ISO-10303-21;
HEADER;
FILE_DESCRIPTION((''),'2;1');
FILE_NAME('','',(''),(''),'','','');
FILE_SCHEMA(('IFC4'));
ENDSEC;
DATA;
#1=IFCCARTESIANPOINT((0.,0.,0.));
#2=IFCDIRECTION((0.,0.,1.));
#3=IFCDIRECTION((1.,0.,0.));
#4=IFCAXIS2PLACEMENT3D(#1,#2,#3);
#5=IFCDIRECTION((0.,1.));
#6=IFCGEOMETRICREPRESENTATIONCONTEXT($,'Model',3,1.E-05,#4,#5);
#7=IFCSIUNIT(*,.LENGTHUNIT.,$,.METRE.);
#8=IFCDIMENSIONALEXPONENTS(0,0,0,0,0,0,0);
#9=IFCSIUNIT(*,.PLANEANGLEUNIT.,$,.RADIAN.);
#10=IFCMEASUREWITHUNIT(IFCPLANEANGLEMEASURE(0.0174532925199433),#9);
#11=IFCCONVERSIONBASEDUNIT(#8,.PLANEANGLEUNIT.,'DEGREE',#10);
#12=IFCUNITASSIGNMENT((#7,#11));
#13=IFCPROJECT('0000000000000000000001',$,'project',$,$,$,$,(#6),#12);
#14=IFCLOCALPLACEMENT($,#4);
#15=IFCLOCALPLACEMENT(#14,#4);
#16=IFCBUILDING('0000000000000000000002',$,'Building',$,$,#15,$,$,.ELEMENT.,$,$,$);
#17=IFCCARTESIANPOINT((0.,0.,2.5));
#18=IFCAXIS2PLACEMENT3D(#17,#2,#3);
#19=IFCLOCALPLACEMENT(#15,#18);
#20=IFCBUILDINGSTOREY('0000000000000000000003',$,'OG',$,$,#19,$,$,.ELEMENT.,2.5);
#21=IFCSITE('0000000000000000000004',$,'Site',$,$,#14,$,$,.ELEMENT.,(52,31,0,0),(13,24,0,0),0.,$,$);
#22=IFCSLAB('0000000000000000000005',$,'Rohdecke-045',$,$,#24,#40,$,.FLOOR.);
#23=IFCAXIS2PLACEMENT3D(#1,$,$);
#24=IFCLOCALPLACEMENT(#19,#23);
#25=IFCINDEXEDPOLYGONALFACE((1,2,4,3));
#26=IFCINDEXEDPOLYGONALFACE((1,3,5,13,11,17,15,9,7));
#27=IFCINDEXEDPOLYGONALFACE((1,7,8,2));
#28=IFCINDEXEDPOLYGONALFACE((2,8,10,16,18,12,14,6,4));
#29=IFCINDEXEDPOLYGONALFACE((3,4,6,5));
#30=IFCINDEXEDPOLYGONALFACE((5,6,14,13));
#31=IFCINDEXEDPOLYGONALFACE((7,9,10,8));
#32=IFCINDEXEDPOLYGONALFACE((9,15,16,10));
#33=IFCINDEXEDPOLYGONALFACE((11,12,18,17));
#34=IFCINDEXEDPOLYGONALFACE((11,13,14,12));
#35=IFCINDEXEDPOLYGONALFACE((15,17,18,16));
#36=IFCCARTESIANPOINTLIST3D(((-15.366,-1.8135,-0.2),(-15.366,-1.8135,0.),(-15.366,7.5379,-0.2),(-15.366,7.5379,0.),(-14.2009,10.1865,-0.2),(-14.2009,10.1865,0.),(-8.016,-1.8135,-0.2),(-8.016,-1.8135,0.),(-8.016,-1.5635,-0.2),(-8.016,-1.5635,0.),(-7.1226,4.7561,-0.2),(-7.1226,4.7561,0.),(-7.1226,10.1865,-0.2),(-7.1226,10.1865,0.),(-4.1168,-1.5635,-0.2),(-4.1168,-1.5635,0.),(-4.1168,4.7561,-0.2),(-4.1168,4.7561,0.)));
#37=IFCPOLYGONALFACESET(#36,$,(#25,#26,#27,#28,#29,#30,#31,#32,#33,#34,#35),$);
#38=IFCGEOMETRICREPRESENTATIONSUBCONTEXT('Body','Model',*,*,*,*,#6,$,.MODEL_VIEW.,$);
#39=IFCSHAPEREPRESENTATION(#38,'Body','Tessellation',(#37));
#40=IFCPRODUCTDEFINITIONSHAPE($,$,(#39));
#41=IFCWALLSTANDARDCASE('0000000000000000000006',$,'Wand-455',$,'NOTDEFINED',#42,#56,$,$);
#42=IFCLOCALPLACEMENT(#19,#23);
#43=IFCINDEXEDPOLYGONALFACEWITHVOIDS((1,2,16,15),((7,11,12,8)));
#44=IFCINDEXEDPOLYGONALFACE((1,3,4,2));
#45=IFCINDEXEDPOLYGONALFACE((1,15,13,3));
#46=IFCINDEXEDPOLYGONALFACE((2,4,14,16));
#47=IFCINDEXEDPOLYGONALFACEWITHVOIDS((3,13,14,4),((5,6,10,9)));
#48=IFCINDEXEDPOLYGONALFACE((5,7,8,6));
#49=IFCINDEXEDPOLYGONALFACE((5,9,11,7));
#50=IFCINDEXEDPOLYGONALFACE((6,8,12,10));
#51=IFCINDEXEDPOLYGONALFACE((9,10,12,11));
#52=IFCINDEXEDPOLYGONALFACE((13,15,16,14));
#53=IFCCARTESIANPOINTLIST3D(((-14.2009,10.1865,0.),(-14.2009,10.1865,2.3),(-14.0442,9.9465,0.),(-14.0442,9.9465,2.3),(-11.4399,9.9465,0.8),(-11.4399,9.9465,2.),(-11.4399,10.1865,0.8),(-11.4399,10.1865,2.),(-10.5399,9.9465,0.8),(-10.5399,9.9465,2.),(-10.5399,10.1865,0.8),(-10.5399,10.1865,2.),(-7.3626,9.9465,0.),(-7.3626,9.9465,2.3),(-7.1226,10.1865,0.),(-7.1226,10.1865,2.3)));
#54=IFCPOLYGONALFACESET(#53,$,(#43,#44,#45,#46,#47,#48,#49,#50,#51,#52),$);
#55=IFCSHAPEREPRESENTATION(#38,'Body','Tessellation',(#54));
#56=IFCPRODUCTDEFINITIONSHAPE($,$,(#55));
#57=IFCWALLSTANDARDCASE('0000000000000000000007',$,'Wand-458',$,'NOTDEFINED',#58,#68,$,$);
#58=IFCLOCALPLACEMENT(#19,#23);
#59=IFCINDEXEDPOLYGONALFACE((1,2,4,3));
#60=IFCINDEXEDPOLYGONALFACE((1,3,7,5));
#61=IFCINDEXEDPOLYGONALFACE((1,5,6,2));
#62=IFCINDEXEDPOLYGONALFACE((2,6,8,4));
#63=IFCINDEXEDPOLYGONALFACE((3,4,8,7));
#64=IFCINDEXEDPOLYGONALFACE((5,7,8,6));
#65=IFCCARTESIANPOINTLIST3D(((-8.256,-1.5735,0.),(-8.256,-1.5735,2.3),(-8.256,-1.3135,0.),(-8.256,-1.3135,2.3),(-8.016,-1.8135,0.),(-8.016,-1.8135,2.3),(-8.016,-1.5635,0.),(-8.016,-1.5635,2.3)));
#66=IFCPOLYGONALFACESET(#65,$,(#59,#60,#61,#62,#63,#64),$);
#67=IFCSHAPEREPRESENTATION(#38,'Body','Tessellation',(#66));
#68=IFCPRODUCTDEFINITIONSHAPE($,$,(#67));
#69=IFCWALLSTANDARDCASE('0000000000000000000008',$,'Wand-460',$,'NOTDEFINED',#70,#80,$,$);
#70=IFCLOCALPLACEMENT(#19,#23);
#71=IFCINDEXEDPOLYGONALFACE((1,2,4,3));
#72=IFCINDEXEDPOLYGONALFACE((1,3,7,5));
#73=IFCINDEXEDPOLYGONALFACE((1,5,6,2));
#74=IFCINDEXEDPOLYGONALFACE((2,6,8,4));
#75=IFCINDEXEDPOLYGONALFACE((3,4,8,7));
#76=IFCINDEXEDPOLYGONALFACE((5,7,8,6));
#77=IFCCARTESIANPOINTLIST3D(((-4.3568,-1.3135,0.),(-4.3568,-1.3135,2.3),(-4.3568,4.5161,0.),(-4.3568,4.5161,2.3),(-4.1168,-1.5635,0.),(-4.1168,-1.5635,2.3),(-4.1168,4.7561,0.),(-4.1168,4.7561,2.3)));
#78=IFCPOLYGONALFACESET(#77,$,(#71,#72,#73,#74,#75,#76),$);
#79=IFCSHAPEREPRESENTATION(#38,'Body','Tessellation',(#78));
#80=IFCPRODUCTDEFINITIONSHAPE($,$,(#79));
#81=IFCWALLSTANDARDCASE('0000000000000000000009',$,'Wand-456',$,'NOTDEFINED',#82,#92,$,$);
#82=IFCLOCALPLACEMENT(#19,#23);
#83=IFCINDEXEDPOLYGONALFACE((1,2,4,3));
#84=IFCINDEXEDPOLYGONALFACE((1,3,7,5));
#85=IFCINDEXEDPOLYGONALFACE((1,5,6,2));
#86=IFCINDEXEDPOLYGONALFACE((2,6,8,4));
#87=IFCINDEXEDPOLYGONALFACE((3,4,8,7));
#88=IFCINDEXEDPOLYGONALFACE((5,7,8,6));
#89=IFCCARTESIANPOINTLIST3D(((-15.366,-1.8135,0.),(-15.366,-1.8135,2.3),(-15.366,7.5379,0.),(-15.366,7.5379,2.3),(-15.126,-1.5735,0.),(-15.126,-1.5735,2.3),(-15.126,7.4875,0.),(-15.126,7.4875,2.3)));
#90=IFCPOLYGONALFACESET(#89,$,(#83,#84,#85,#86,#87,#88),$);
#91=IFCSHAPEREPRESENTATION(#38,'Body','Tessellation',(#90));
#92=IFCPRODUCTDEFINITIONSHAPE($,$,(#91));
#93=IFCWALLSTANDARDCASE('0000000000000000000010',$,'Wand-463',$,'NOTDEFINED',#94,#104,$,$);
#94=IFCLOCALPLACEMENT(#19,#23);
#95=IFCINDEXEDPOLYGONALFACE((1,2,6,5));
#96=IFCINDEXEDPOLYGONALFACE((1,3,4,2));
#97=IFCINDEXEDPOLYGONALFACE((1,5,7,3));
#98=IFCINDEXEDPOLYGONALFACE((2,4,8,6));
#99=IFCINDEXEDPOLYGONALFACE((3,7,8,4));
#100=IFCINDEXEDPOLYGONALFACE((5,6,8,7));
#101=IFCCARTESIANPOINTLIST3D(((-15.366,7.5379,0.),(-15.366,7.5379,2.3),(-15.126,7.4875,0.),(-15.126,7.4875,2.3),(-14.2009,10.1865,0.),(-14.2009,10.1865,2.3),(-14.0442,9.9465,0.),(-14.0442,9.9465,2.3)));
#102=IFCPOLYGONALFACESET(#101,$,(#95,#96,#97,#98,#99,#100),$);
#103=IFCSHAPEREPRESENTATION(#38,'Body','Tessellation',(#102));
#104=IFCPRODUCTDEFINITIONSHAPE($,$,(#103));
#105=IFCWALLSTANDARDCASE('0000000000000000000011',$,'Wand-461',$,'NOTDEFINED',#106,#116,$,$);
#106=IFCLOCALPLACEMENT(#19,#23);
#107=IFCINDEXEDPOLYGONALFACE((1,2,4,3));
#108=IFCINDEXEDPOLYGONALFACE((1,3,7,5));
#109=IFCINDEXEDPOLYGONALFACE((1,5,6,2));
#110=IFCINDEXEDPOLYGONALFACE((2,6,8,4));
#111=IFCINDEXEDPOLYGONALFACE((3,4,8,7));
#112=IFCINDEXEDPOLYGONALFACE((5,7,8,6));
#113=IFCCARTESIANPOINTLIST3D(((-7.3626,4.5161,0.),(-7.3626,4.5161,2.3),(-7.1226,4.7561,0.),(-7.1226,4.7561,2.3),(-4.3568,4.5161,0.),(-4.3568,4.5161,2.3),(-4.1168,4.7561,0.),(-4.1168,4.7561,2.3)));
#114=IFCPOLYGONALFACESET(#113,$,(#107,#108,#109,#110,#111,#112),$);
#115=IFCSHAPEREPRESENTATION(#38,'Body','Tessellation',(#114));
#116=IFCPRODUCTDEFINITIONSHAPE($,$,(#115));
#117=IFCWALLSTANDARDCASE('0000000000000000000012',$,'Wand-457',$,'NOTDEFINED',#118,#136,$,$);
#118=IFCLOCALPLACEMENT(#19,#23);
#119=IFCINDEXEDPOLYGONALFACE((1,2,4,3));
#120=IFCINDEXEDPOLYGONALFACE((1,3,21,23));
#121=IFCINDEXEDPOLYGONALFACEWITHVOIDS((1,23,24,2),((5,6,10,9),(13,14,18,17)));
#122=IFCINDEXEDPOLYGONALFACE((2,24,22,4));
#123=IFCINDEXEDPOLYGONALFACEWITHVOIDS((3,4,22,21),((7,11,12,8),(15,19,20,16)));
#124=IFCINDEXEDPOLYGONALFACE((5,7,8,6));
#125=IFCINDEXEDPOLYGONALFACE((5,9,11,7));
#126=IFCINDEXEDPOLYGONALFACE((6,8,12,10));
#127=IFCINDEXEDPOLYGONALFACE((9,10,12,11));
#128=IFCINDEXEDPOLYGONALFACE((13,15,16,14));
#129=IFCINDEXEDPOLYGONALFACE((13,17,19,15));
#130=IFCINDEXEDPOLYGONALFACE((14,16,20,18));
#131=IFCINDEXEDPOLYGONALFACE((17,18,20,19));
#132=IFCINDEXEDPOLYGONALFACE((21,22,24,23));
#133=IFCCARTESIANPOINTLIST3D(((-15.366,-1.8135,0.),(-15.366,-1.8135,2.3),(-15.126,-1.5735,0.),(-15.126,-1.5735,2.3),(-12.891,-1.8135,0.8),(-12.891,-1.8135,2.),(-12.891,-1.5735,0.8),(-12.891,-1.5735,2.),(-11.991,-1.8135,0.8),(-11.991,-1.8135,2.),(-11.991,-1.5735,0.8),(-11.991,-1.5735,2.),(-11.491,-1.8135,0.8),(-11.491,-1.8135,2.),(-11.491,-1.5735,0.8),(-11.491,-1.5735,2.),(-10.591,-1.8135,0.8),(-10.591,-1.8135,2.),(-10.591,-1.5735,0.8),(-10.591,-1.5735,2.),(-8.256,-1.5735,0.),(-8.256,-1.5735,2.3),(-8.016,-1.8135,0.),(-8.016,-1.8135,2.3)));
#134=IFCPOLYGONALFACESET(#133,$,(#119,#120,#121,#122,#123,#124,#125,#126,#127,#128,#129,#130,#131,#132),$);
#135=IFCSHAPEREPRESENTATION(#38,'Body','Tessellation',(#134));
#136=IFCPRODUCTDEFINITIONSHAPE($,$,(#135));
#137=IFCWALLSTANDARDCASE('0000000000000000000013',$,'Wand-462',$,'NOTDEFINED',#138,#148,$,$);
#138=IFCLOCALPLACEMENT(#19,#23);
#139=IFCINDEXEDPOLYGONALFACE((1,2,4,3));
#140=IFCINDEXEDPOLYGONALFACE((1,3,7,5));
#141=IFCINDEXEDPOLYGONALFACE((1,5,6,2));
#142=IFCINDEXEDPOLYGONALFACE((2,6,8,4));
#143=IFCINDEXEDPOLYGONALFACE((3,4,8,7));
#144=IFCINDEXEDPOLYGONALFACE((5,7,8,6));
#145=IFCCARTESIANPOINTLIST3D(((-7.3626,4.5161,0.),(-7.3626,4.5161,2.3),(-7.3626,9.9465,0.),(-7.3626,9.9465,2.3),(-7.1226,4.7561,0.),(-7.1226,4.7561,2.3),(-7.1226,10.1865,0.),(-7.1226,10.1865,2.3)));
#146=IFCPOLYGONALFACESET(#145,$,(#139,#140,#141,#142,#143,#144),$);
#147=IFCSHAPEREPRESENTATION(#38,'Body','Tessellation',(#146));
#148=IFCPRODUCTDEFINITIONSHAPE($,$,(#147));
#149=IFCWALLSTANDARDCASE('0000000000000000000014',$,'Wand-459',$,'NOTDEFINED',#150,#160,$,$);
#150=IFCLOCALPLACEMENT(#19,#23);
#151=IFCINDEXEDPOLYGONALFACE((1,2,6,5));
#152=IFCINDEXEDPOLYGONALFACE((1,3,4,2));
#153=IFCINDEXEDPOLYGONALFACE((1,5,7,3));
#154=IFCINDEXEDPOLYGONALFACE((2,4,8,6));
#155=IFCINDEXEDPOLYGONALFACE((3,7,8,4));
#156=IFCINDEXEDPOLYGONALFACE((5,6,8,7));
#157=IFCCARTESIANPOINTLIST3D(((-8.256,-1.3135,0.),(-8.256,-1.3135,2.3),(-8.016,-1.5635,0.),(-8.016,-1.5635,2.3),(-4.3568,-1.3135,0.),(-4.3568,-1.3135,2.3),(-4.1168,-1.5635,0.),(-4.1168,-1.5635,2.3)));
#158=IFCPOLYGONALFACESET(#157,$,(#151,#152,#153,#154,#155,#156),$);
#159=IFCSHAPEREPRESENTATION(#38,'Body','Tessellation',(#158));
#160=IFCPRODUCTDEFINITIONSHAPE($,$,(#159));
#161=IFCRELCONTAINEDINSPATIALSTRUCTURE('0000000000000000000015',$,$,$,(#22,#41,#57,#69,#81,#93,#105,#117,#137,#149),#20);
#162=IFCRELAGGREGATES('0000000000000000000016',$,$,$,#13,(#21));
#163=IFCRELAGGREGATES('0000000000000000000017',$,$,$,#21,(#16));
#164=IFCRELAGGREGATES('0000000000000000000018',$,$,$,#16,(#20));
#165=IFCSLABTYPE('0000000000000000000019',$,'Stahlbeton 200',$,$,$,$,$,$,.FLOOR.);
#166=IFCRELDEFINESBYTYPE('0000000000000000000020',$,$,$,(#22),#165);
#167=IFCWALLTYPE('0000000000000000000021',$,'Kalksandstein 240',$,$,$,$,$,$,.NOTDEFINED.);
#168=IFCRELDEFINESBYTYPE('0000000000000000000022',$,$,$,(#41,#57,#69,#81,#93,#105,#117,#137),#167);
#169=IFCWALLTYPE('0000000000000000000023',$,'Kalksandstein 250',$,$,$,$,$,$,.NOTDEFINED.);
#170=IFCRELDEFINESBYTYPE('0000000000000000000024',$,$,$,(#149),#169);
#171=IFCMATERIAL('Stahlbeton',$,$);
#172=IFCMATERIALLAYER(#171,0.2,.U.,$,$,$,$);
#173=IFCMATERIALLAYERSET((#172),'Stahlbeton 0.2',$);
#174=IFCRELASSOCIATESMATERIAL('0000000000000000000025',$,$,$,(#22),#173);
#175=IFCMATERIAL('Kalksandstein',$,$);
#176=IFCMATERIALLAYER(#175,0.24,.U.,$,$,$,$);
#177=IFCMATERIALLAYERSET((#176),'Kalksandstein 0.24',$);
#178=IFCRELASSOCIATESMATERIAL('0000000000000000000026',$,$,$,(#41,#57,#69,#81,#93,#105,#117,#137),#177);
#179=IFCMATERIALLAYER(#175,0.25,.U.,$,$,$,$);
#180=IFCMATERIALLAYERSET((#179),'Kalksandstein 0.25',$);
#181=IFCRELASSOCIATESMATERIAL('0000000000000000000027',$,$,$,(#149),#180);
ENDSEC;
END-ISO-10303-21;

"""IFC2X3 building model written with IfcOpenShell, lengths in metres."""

from ifc_helpers import new_model, entity, si_unit, converted_unit, direction, frame, origin_with_axes, origin_2d_with_axis, place, context, subcontext, project, spatial, polyline, rectangle, outline, extrude, material, layer, layer_set, layer_usage, type_object, element, save


model = new_model("IFC2X3")

# Units and contexts
model_context = context("Model", 3, precision=1e-05, world=origin_with_axes(), true_north=direction((0.0, 1.0)))
body_context = subcontext(model_context, "Body", "Model", "MODEL_VIEW")
ifc_project = project(units=[si_unit("LENGTHUNIT", "METRE"), converted_unit("PLANEANGLEUNIT", "DEGREE", entity("IfcPlaneAngleMeasure", 0.0174532925199433), si_unit("PLANEANGLEUNIT", "RADIAN"), dimensions=[0, 0, 0, 0, 0, 0, 0])], contexts=[model_context])

# Site, building, storey
site_placement = place(None, origin_with_axes())
site = spatial("IfcSite", under=ifc_project, at=site_placement, Name="Site", CompositionType="ELEMENT", RefLatitude=(52, 31, 0, 0), RefLongitude=(13, 24, 0, 0), RefElevation=0.0)
building_placement = place(site_placement, origin_with_axes())
building = spatial("IfcBuilding", under=site, at=building_placement, Name="Building", CompositionType="ELEMENT")
storey_placement = place(building_placement, frame((0.0, 0.0, 2.5), z_axis=(0.0, 0.0, 1.0), x_axis=(1.0, 0.0, 0.0)))
storey = spatial("IfcBuildingStorey", under=building, at=storey_placement, Name="OG", CompositionType="ELEMENT", Elevation=2.5)

# Slab
ifc_material_1 = material(Name="Stahlbeton")
ifc_layer_1 = layer(ifc_material_1, 0.2, ventilated="UNKNOWN")
ifc_layer_set_1 = layer_set([ifc_layer_1], Name="Stahlbeton 0.2")
ifc_layer_usage_1 = layer_usage(ifc_layer_set_1, "AXIS3", "NEGATIVE", 0.2)
slab_type = type_object("IfcSlabType", Name="Stahlbeton 200", PredefinedType="FLOOR")
slab_placement = place(storey_placement, frame((-14.2009, 10.1865, 0.0), z_axis=(0.0, 0.0, 1.0), x_axis=(1.0, 0.0, 0.0)))
element("IfcSlab", 1, at=slab_placement, inside=storey, type_object=slab_type, material=ifc_layer_usage_1, Name="Rohdecke-045", PredefinedType="FLOOR", context=body_context, shape_type="SweptSolid", body=[
    extrude(outline(polyline([(0.0, 0.0), (-1.1652, -2.6486), (-1.1652, -12.0), (6.1848, -12.0), (6.1848, -11.75), (10.084, -11.75), (10.084, -5.4304), (7.0783, -5.4304), (7.0783, 0.0), (0.0, 0.0)])), frame((0.0, 0.0, -0.2), z_axis=(0.0, 0.0, 1.0), x_axis=(1.0, 0.0, 0.0)), (0.0, 0.0, 1.0), 0.2),
])

# Wall, opening
ifc_material_2 = material(Name="Kalksandstein")
ifc_layer_2 = layer(ifc_material_2, 0.24, ventilated="UNKNOWN")
ifc_layer_set_2 = layer_set([ifc_layer_2], Name="Kalksandstein 0.24")
ifc_layer_usage_2 = layer_usage(ifc_layer_set_2, "AXIS2", "POSITIVE", 0.0)
wall_type_1 = type_object("IfcWallType", Name="Kalksandstein 240", PredefinedType="NOTDEFINED")
wall_1_placement = place(storey_placement, frame((-7.1226, 10.1865, 0.0), z_axis=(0.0, 0.0, 1.0), x_axis=(-1.0, 0.0, 0.0)))
wall_1 = element("IfcWallStandardCase", 2, at=wall_1_placement, inside=storey, type_object=wall_type_1, material=ifc_layer_usage_2, Name="Wand-455", ObjectType="NOTDEFINED", context=body_context, shape_type="SweptSolid", body=[
    extrude(outline(polyline([(0.0, 0.0), (7.0783, 0.0), (6.9216, 0.24), (0.24, 0.24), (0.0, 0.0)])), origin_with_axes(), (0.0, 0.0, 1.0), 2.3),
])
opening_1_placement = place(wall_1_placement, frame((3.8673, 0.0, 0.8), z_axis=(0.0, 0.0, 1.0), x_axis=(1.0, 0.0, 0.0)))
element("IfcOpeningElement", 3, at=opening_1_placement, cuts=wall_1, context=body_context, shape_type="SweptSolid", body=[
    extrude(rectangle(XDim=0.9, YDim=1.2, at=origin_2d_with_axis()), frame((0.0, 0.24, 0.6), z_axis=(0.0, 1.0, 0.0), x_axis=(1.0, 0.0, 0.0)), (0.0, 0.0, -1.0), 0.72),
])

# Walls
ifc_layer_usage_3 = layer_usage(ifc_layer_set_2, "AXIS2", "POSITIVE", 0.0)
wall_2_placement = place(storey_placement, frame((-8.016, -1.8135, 0.0), z_axis=(0.0, 0.0, 1.0), x_axis=(0.0, 1.0, 0.0)))
element("IfcWallStandardCase", 4, at=wall_2_placement, inside=storey, type_object=wall_type_1, material=ifc_layer_usage_3, Name="Wand-458", ObjectType="NOTDEFINED", context=body_context, shape_type="SweptSolid", body=[
    extrude(outline(polyline([(0.0, 0.0), (0.25, 0.0), (0.5, 0.24), (0.24, 0.24), (0.0, 0.0)])), origin_with_axes(), (0.0, 0.0, 1.0), 2.3),
])
ifc_layer_usage_4 = layer_usage(ifc_layer_set_2, "AXIS2", "POSITIVE", 0.0)
wall_3_placement = place(storey_placement, frame((-4.1168, -1.5635, 0.0), z_axis=(0.0, 0.0, 1.0), x_axis=(0.0, 1.0, 0.0)))
element("IfcWallStandardCase", 5, at=wall_3_placement, inside=storey, type_object=wall_type_1, material=ifc_layer_usage_4, Name="Wand-460", ObjectType="NOTDEFINED", context=body_context, shape_type="SweptSolid", body=[
    extrude(outline(polyline([(0.0, 0.0), (6.3196, 0.0), (6.0796, 0.24), (0.25, 0.24), (0.0, 0.0)])), origin_with_axes(), (0.0, 0.0, 1.0), 2.3),
])
ifc_layer_usage_5 = layer_usage(ifc_layer_set_2, "AXIS2", "POSITIVE", 0.0)
wall_4_placement = place(storey_placement, frame((-15.366, 7.5379, 0.0), z_axis=(0.0, 0.0, 1.0), x_axis=(0.0, -1.0, 0.0)))
element("IfcWallStandardCase", 6, at=wall_4_placement, inside=storey, type_object=wall_type_1, material=ifc_layer_usage_5, Name="Wand-456", ObjectType="NOTDEFINED", context=body_context, shape_type="SweptSolid", body=[
    extrude(outline(polyline([(0.0, 0.0), (9.3514, 0.0), (9.1114, 0.24), (0.0505, 0.24), (0.0, 0.0)])), origin_with_axes(), (0.0, 0.0, 1.0), 2.3),
])
ifc_layer_usage_6 = layer_usage(ifc_layer_set_2, "AXIS2", "POSITIVE", 0.0)
wall_5_placement = place(storey_placement, frame((-14.2009, 10.1865, 0.0), z_axis=(0.0, 0.0, 1.0), x_axis=(-0.402674, -0.915343, 0.0)))
element("IfcWallStandardCase", 7, at=wall_5_placement, inside=storey, type_object=wall_type_1, material=ifc_layer_usage_6, Name="Wand-463", ObjectType="NOTDEFINED", context=body_context, shape_type="SweptSolid", body=[
    extrude(outline(polyline([(0.0, 0.0), (2.8935, 0.0), (2.8431, 0.24), (0.1566, 0.24), (0.0, 0.0)])), origin_with_axes(), (0.0, 0.0, 1.0), 2.3),
])
ifc_layer_usage_7 = layer_usage(ifc_layer_set_2, "AXIS2", "POSITIVE", 0.0)
wall_6_placement = place(storey_placement, frame((-4.1168, 4.7561, 0.0), z_axis=(0.0, 0.0, 1.0), x_axis=(-1.0, 0.0, 0.0)))
element("IfcWallStandardCase", 8, at=wall_6_placement, inside=storey, type_object=wall_type_1, material=ifc_layer_usage_7, Name="Wand-461", ObjectType="NOTDEFINED", context=body_context, shape_type="SweptSolid", body=[
    extrude(outline(polyline([(0.0, 0.0), (3.0058, 0.0), (3.2458, 0.24), (0.24, 0.24), (0.0, 0.0)])), origin_with_axes(), (0.0, 0.0, 1.0), 2.3),
])

# Wall, openings
ifc_layer_usage_8 = layer_usage(ifc_layer_set_2, "AXIS2", "POSITIVE", 0.0)
wall_7_placement = place(storey_placement, frame((-15.366, -1.8135, 0.0), z_axis=(0.0, 0.0, 1.0), x_axis=(1.0, 0.0, 0.0)))
wall_7 = element("IfcWallStandardCase", 9, at=wall_7_placement, inside=storey, type_object=wall_type_1, material=ifc_layer_usage_8, Name="Wand-457", ObjectType="NOTDEFINED", context=body_context, shape_type="SweptSolid", body=[
    extrude(outline(polyline([(0.0, 0.0), (7.35, 0.0), (7.11, 0.24), (0.24, 0.24), (0.0, 0.0)])), origin_with_axes(), (0.0, 0.0, 1.0), 2.3),
])
opening_2_placement = place(wall_7_placement, frame((2.925, 0.0, 0.8), z_axis=(0.0, 0.0, 1.0), x_axis=(1.0, 0.0, 0.0)))
element("IfcOpeningElement", 10, at=opening_2_placement, cuts=wall_7, context=body_context, shape_type="SweptSolid", body=[
    extrude(rectangle(XDim=0.9, YDim=1.2, at=origin_2d_with_axis()), frame((0.0, 0.24, 0.6), z_axis=(0.0, 1.0, 0.0), x_axis=(1.0, 0.0, 0.0)), (0.0, 0.0, -1.0), 0.72),
])
opening_3_placement = place(wall_7_placement, frame((4.325, 0.0, 0.8), z_axis=(0.0, 0.0, 1.0), x_axis=(1.0, 0.0, 0.0)))
element("IfcOpeningElement", 11, at=opening_3_placement, cuts=wall_7, context=body_context, shape_type="SweptSolid", body=[
    extrude(rectangle(XDim=0.9, YDim=1.2, at=origin_2d_with_axis()), frame((0.0, 0.24, 0.6), z_axis=(0.0, 1.0, 0.0), x_axis=(1.0, 0.0, 0.0)), (0.0, 0.0, -1.0), 0.72),
])

# Walls
ifc_layer_usage_9 = layer_usage(ifc_layer_set_2, "AXIS2", "POSITIVE", 0.0)
wall_8_placement = place(storey_placement, frame((-7.1226, 4.7561, 0.0), z_axis=(0.0, 0.0, 1.0), x_axis=(0.0, 1.0, 0.0)))
element("IfcWallStandardCase", 12, at=wall_8_placement, inside=storey, type_object=wall_type_1, material=ifc_layer_usage_9, Name="Wand-462", ObjectType="NOTDEFINED", context=body_context, shape_type="SweptSolid", body=[
    extrude(outline(polyline([(0.0, 0.0), (5.4304, 0.0), (5.1904, 0.24), (-0.24, 0.24), (0.0, 0.0)])), origin_with_axes(), (0.0, 0.0, 1.0), 2.3),
])
ifc_layer_3 = layer(ifc_material_2, 0.25, ventilated="UNKNOWN")
ifc_layer_set_3 = layer_set([ifc_layer_3], Name="Kalksandstein 0.25")
ifc_layer_usage_10 = layer_usage(ifc_layer_set_3, "AXIS2", "POSITIVE", 0.0)
wall_type_2 = type_object("IfcWallType", Name="Kalksandstein 250", PredefinedType="NOTDEFINED")
wall_9_placement = place(storey_placement, frame((-8.016, -1.5635, 0.0), z_axis=(0.0, 0.0, 1.0), x_axis=(1.0, 0.0, 0.0)))
element("IfcWallStandardCase", 13, at=wall_9_placement, inside=storey, type_object=wall_type_2, material=ifc_layer_usage_10, Name="Wand-459", ObjectType="NOTDEFINED", context=body_context, shape_type="SweptSolid", body=[
    extrude(outline(polyline([(0.0, 0.0), (3.8992, 0.0), (3.6592, 0.25), (-0.24, 0.25), (0.0, 0.0)])), origin_with_axes(), (0.0, 0.0, 1.0), 2.3),
])

save(model, "model.ifc")
